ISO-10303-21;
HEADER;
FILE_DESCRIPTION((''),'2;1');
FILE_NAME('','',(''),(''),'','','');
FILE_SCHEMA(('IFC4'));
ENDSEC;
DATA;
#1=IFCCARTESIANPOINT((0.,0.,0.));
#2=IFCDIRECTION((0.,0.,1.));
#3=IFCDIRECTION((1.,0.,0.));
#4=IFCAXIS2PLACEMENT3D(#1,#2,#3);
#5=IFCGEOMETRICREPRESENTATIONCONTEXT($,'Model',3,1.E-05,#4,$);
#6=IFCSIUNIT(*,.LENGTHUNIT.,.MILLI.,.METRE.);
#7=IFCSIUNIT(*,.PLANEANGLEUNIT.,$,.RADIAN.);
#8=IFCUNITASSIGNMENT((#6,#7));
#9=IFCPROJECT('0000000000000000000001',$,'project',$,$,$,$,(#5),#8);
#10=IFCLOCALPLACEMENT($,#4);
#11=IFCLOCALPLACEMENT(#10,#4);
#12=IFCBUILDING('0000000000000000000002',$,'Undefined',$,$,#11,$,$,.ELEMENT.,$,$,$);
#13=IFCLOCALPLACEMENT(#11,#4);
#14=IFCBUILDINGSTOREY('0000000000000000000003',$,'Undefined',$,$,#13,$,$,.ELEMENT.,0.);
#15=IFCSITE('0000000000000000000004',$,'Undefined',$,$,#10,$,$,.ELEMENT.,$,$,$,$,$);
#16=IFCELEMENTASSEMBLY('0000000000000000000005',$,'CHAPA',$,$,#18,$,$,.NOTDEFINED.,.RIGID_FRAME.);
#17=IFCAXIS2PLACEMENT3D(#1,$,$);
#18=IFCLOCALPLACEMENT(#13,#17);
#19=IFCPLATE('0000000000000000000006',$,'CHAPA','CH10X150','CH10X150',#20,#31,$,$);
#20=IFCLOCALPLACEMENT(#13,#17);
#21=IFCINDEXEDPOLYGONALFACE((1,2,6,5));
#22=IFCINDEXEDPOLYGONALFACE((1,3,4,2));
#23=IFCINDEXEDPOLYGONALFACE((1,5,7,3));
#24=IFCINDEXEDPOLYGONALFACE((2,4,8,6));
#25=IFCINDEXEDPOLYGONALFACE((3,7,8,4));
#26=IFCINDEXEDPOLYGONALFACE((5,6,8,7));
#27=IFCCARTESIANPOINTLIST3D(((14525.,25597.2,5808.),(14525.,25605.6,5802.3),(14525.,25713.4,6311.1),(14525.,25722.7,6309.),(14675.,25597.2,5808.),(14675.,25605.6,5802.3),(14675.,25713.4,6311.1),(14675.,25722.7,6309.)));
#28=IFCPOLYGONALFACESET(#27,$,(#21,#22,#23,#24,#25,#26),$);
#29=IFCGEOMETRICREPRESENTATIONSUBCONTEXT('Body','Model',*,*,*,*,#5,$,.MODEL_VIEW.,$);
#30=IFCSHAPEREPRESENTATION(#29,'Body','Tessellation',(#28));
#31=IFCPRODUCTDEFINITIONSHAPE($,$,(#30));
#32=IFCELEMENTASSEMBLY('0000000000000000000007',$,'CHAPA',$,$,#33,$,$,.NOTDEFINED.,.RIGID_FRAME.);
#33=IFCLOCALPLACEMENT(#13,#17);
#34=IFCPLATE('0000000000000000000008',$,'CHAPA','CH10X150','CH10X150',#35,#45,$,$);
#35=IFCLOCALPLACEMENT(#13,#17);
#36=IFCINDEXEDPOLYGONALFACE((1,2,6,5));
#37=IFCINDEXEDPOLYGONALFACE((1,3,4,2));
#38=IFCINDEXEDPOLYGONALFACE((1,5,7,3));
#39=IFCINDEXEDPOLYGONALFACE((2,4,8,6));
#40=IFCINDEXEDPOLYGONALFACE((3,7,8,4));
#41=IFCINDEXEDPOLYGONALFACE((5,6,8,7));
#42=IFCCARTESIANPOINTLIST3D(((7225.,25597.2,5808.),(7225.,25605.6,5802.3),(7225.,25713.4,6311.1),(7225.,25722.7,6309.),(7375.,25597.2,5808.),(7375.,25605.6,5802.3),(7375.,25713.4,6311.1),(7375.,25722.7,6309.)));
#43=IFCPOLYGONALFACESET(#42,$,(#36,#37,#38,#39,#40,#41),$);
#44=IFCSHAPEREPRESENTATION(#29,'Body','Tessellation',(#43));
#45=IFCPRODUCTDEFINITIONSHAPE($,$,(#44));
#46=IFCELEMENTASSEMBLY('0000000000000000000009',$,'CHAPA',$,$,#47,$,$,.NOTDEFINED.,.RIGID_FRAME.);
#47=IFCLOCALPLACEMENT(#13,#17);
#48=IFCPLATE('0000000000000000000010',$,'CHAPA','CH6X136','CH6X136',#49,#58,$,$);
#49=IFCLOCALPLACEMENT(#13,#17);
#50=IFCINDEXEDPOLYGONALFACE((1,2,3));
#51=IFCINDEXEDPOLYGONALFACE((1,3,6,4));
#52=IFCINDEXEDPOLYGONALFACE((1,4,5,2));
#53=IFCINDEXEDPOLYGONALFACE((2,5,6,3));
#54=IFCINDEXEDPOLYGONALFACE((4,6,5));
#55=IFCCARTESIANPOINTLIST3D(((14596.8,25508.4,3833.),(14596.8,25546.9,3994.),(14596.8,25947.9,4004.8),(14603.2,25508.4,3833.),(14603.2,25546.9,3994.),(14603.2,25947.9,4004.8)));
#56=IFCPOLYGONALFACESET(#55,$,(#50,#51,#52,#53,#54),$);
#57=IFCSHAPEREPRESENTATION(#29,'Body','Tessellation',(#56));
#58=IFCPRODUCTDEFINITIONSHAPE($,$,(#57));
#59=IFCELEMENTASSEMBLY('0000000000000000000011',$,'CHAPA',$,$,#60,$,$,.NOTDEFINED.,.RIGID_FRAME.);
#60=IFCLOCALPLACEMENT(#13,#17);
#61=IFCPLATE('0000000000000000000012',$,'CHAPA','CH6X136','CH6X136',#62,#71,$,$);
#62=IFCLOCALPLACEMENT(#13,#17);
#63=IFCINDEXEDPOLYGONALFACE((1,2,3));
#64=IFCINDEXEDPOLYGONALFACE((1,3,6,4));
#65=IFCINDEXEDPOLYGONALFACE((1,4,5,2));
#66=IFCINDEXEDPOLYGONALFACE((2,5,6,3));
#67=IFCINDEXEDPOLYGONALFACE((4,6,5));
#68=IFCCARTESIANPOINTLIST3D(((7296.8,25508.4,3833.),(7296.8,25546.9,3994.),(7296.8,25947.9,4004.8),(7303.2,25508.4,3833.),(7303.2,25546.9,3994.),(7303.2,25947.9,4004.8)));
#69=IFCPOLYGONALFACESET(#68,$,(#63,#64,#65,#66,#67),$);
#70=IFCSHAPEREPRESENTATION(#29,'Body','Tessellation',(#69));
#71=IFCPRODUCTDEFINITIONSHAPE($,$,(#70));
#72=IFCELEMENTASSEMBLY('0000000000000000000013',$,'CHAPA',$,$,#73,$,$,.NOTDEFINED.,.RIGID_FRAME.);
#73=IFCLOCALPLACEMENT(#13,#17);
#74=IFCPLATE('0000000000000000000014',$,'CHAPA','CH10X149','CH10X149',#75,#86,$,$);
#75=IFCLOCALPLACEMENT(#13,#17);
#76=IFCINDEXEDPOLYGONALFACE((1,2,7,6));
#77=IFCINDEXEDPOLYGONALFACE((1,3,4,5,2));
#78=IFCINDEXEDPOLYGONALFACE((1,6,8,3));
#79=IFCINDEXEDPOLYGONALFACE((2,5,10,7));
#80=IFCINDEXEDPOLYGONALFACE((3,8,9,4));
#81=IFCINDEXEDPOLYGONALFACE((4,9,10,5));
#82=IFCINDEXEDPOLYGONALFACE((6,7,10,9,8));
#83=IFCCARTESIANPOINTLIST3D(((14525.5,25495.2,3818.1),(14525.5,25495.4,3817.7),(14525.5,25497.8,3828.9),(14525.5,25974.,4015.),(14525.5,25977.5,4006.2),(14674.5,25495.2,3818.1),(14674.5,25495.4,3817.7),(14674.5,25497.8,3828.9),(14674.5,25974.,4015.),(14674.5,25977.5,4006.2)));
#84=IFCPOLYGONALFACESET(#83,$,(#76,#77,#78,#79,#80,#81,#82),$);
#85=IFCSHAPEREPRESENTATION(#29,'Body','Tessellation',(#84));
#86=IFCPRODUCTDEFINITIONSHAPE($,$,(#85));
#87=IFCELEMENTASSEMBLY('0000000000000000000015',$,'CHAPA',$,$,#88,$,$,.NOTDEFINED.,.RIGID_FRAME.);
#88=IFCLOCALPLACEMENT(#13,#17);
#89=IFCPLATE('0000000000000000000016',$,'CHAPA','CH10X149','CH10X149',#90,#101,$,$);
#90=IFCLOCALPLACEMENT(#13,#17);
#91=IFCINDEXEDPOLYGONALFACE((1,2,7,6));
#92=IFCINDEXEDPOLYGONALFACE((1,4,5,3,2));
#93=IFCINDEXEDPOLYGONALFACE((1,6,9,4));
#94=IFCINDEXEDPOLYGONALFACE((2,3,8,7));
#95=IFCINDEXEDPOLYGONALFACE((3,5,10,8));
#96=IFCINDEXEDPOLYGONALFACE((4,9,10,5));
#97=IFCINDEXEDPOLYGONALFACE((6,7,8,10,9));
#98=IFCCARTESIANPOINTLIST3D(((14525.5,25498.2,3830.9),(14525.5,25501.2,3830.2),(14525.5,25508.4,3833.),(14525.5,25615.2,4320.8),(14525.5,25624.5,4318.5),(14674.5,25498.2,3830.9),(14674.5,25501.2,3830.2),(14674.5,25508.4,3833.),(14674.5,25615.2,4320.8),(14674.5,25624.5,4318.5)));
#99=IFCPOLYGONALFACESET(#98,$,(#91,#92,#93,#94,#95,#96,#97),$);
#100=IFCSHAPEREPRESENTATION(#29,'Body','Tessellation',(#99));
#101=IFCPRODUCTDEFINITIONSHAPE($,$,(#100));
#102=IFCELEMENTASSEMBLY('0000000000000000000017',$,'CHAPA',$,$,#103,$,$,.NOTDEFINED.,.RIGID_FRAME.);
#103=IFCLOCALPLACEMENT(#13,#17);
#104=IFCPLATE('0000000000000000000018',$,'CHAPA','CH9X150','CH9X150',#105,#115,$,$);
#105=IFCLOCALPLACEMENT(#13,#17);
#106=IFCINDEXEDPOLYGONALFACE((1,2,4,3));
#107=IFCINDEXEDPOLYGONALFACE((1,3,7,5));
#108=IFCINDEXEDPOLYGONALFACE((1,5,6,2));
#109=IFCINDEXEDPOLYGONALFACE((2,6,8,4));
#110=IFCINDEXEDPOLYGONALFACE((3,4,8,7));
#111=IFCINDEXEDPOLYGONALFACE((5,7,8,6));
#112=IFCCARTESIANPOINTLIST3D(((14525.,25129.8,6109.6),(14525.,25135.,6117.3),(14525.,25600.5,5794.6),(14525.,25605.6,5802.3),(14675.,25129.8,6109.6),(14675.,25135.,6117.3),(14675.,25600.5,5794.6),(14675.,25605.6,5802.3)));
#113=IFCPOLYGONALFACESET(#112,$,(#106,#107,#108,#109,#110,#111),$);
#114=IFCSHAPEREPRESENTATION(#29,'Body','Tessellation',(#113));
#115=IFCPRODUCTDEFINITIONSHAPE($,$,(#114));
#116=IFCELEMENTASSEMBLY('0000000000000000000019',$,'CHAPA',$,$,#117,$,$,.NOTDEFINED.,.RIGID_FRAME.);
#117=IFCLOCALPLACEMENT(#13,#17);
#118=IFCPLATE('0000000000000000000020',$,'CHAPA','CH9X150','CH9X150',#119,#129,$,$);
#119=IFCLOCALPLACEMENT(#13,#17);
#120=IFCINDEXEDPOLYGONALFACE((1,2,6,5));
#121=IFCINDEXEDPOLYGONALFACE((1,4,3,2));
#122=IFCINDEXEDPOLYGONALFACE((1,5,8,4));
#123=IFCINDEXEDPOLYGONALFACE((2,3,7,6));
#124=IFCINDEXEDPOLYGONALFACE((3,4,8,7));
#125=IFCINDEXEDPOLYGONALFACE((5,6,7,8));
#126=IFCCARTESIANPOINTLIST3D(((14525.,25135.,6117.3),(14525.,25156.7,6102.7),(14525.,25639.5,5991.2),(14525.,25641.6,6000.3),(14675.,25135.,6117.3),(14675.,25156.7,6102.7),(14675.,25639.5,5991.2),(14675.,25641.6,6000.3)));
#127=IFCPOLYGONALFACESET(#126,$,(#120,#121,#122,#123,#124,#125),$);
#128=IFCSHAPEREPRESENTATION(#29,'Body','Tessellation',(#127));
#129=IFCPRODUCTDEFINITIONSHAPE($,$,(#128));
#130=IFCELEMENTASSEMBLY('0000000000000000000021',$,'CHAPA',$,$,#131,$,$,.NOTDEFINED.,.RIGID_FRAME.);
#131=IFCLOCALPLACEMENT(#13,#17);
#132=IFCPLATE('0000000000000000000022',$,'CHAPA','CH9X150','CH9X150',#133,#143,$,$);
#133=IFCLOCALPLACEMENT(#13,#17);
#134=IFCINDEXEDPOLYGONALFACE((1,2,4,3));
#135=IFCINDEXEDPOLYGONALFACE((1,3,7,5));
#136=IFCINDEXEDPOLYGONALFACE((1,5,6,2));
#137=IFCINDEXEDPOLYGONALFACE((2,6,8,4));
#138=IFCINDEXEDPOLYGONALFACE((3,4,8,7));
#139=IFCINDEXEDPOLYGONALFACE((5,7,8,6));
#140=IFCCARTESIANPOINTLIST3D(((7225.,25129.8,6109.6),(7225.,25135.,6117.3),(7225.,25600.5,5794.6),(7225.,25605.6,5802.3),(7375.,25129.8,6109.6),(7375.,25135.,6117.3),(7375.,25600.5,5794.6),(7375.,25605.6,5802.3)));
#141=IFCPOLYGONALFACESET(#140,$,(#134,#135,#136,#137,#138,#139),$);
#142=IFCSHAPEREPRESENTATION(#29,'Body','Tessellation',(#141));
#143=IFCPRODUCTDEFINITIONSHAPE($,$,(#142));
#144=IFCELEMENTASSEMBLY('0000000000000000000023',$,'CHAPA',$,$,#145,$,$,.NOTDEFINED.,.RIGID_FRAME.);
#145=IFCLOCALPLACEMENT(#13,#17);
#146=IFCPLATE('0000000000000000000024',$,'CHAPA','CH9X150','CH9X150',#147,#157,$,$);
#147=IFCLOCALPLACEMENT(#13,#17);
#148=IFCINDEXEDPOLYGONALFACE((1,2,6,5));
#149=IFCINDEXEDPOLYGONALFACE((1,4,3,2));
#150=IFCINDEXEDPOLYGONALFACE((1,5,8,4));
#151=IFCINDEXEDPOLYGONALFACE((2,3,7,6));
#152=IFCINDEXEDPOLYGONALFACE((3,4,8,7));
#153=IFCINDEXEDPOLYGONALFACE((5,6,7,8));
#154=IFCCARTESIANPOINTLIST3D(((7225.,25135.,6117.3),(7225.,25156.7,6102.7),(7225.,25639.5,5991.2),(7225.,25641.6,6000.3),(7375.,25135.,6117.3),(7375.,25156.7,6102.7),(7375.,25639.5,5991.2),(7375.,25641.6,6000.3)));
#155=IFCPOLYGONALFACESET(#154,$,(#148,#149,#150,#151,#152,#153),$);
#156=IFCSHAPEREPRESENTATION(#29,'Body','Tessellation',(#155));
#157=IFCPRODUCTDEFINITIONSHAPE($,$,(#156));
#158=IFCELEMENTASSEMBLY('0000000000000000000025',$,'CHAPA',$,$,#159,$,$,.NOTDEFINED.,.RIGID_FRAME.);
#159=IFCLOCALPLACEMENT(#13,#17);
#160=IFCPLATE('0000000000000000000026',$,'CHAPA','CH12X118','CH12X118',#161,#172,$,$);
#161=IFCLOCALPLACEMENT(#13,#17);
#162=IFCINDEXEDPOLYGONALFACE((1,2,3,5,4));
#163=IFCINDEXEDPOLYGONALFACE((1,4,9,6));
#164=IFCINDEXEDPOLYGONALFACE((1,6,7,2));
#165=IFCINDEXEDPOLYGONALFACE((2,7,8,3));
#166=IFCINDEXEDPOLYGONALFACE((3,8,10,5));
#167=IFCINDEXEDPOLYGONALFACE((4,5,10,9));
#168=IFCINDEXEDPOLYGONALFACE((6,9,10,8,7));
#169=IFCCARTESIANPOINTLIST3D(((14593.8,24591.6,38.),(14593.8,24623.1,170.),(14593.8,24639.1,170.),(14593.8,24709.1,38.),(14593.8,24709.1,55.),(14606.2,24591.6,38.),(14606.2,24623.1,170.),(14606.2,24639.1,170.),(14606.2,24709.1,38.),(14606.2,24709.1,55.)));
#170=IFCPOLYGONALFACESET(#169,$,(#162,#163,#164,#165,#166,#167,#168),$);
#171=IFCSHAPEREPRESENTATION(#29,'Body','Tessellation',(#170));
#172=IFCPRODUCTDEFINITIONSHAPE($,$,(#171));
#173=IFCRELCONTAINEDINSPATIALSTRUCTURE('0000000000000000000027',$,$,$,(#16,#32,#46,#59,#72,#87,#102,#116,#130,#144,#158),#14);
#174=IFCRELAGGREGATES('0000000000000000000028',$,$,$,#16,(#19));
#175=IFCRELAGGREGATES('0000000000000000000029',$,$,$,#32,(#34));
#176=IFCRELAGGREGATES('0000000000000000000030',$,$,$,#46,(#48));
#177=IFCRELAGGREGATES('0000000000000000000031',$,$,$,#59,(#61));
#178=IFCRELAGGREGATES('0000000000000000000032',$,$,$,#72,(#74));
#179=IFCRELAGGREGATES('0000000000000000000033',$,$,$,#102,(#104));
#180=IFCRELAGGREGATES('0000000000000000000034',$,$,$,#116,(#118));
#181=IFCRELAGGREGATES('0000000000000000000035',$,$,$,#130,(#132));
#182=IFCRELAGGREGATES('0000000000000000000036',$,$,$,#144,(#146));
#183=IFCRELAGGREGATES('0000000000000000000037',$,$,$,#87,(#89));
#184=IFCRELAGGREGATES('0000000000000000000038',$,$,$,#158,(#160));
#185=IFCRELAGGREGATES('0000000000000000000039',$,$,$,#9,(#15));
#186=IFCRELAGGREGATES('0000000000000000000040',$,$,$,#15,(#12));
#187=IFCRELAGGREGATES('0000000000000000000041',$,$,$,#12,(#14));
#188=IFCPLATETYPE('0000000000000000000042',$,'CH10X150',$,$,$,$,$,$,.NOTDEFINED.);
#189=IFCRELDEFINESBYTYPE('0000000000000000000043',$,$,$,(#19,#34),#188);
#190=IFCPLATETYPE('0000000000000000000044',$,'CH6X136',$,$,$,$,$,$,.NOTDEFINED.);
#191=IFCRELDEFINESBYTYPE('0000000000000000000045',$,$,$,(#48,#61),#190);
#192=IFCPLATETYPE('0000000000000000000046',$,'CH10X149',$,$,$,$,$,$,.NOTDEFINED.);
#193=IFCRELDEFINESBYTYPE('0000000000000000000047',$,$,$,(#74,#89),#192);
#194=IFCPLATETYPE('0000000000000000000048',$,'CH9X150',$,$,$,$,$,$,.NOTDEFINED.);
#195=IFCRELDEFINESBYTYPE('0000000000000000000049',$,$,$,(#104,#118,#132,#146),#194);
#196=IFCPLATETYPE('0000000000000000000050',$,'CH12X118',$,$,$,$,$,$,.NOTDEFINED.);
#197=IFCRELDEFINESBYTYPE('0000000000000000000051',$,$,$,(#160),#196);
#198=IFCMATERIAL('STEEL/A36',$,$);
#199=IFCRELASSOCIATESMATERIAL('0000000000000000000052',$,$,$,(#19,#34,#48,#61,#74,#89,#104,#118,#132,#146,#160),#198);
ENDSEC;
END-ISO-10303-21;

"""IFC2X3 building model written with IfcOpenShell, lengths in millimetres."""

from ifc_helpers import new_model, si_unit, frame, origin_with_axes, place, context, subcontext, project, spatial, polyline, outline, extrude, clip, halfspace, material, type_object, element, aggregate, save


model = new_model("IFC2X3")

# Units and contexts
model_context = context("Model", 3, precision=1e-05, world=origin_with_axes())
body_context = subcontext(model_context, "Body", "Model", "MODEL_VIEW")
ifc_project = project(units=[si_unit("LENGTHUNIT", "METRE", prefix="MILLI"), si_unit("PLANEANGLEUNIT", "RADIAN")], contexts=[model_context])

# Site, building, storey
site_placement = place(None, origin_with_axes())
site = spatial("IfcSite", under=ifc_project, at=site_placement, Name="Undefined", CompositionType="ELEMENT")
building_placement = place(site_placement, origin_with_axes())
building = spatial("IfcBuilding", under=site, at=building_placement, Name="Undefined", CompositionType="ELEMENT")
storey_placement = place(building_placement, origin_with_axes())
storey = spatial("IfcBuildingStorey", under=building, at=storey_placement, Name="Undefined", CompositionType="ELEMENT", Elevation=0.0)

# Element assembly
assembly_1_placement = place(storey_placement, origin_with_axes())
assembly_1 = element("IfcElementAssembly", 1, at=assembly_1_placement, inside=storey, Name="CHAPA", AssemblyPlace="NOTDEFINED", PredefinedType="RIGID_FRAME")

# Plate
ifc_material_1 = material(Name="STEEL/A36")
plate_type_1 = type_object("IfcPlateType", Name="CH10X150", PredefinedType="NOTDEFINED")
plate_1_placement = place(assembly_1_placement, frame((14675.0, 25718.1, 6310.1), z_axis=(0.0, 0.97433, -0.225124), x_axis=(0.0, -0.225124, -0.97433)))
plate_1 = element("IfcPlate", 2, at=plate_1_placement, type_object=plate_type_1, material=ifc_material_1, Name="CHAPA", Description="CH10X150", ObjectType="CH10X150", context=body_context, shape_type="Clipping", body=[
    clip(extrude(outline(polyline([(0.0, 0.0), (520.0, 0.0), (520.0, 150.0), (0.0, 150.0), (0.0, 0.0)])), frame((0.0, 0.0, -4.8), z_axis=(0.0, 0.0, 1.0), x_axis=(1.0, 0.0, 0.0)), (0.0, 0.0, 1.0), 9.5), halfspace(frame((516.4, -500.0, -4.7), z_axis=(0.934951, 0.0, -0.354778), x_axis=(0.354778, 0.0, 0.934951)), False)),
])
aggregate(assembly_1, [plate_1])

# Element assemblies, plates
assembly_2_placement = place(storey_placement, origin_with_axes())
assembly_2 = element("IfcElementAssembly", 3, at=assembly_2_placement, inside=storey, Name="CHAPA", AssemblyPlace="NOTDEFINED", PredefinedType="RIGID_FRAME")
plate_2_placement = place(assembly_2_placement, frame((7375.0, 25718.1, 6310.1), z_axis=(0.0, 0.97433, -0.225124), x_axis=(0.0, -0.225124, -0.97433)))
plate_2 = element("IfcPlate", 4, at=plate_2_placement, type_object=plate_type_1, material=ifc_material_1, Name="CHAPA", Description="CH10X150", ObjectType="CH10X150", context=body_context, shape_type="Clipping", body=[
    clip(extrude(outline(polyline([(0.0, 0.0), (520.0, 0.0), (520.0, 150.0), (0.0, 150.0), (0.0, 0.0)])), frame((0.0, 0.0, -4.8), z_axis=(0.0, 0.0, 1.0), x_axis=(1.0, 0.0, 0.0)), (0.0, 0.0, 1.0), 9.5), halfspace(frame((516.4, -500.0, -4.7), z_axis=(0.934951, 0.0, -0.354778), x_axis=(0.354778, 0.0, 0.934951)), False)),
])
aggregate(assembly_2, [plate_2])
assembly_3_placement = place(storey_placement, origin_with_axes())
assembly_3 = element("IfcElementAssembly", 5, at=assembly_3_placement, inside=storey, Name="CHAPA", AssemblyPlace="NOTDEFINED", PredefinedType="RIGID_FRAME")
plate_type_2 = type_object("IfcPlateType", Name="CH6X136", PredefinedType="NOTDEFINED")
plate_3_placement = place(assembly_3_placement, frame((14600.0, 25546.9, 3994.0), z_axis=(-1.0, 0.0, 0.0), x_axis=(0.0, 0.999636, 0.026972)))
plate_3 = element("IfcPlate", 6, at=plate_3_placement, type_object=plate_type_2, material=ifc_material_1, Name="CHAPA", Description="CH6X136", ObjectType="CH6X136", context=body_context, shape_type="SweptSolid", body=[
    extrude(outline(polyline([(0.0, 0.0), (401.1, 0.0), (-42.8, 159.9), (0.0, 0.0)])), frame((0.0, 0.0, -3.1), z_axis=(0.0, 0.0, 1.0), x_axis=(1.0, 0.0, 0.0)), (0.0, 0.0, 1.0), 6.3),
])
aggregate(assembly_3, [plate_3])
assembly_4_placement = place(storey_placement, origin_with_axes())
assembly_4 = element("IfcElementAssembly", 7, at=assembly_4_placement, inside=storey, Name="CHAPA", AssemblyPlace="NOTDEFINED", PredefinedType="RIGID_FRAME")
plate_4_placement = place(assembly_4_placement, frame((7300.0, 25546.9, 3994.0), z_axis=(-1.0, 0.0, 0.0), x_axis=(0.0, 0.999636, 0.026972)))
plate_4 = element("IfcPlate", 8, at=plate_4_placement, type_object=plate_type_2, material=ifc_material_1, Name="CHAPA", Description="CH6X136", ObjectType="CH6X136", context=body_context, shape_type="SweptSolid", body=[
    extrude(outline(polyline([(0.0, 0.0), (401.1, 0.0), (-42.8, 159.9), (0.0, 0.0)])), frame((0.0, 0.0, -3.1), z_axis=(0.0, 0.0, 1.0), x_axis=(1.0, 0.0, 0.0)), (0.0, 0.0, 1.0), 6.3),
])
aggregate(assembly_4, [plate_4])
assembly_5_placement = place(storey_placement, origin_with_axes())
assembly_5 = element("IfcElementAssembly", 9, at=assembly_5_placement, inside=storey, Name="CHAPA", AssemblyPlace="NOTDEFINED", PredefinedType="RIGID_FRAME")
plate_type_3 = type_object("IfcPlateType", Name="CH10X149", PredefinedType="NOTDEFINED")
plate_5_placement = place(assembly_5_placement, frame((14525.5, 25975.7, 4010.6), z_axis=(0.0, 0.364063, -0.931374), x_axis=(1.0, 0.0, 0.0)))
plate_5 = element("IfcPlate", 10, at=plate_5_placement, type_object=plate_type_3, material=ifc_material_1, Name="CHAPA", Description="CH10X149", ObjectType="CH10X149", context=body_context, shape_type="Clipping", body=[
    clip(extrude(outline(polyline([(0.0, 0.0), (149.0, 0.0), (149.0, 517.6), (0.0, 517.6), (0.0, 0.0)])), frame((0.0, 0.0, -4.8), z_axis=(0.0, 0.0, 1.0), x_axis=(1.0, 0.0, 0.0)), (0.0, 0.0, 1.0), 9.5), halfspace(frame((149.0, 517.9, 4.7), z_axis=(0.0, 0.821204, -0.570634), x_axis=(-1.0, 0.0, 0.0)), False)),
])
aggregate(assembly_5, [plate_5])
assembly_6_placement = place(storey_placement, origin_with_axes())
assembly_6 = element("IfcElementAssembly", 11, at=assembly_6_placement, inside=storey, Name="CHAPA", AssemblyPlace="NOTDEFINED", PredefinedType="RIGID_FRAME")
plate_6_placement = place(assembly_6_placement, frame((14525.5, 25619.9, 4319.6), z_axis=(0.0, 0.972612, -0.232434), x_axis=(1.0, 0.000007, 0.000031)))
plate_6 = element("IfcPlate", 12, at=plate_6_placement, type_object=plate_type_3, material=ifc_material_1, Name="CHAPA", Description="CH10X149", ObjectType="CH10X149", context=body_context, shape_type="Clipping", body=[
    clip(extrude(outline(polyline([(0.0, 0.0), (70.9, 0.0), (149.0, 0.0), (149.0, 503.6), (0.0, 503.6), (0.0, 0.0)])), frame((0.0, 0.0, -4.8), z_axis=(0.0, 0.0, 1.0), x_axis=(1.0, 0.0, 0.0)), (0.0, 0.0, 1.0), 9.5), halfspace(frame((70.9, 499.2, 4.7), z_axis=(-0.000026, 0.821245, 0.570575), x_axis=(-1.0, -0.000032, 0.0)), False)),
])
assembly_7_placement = place(storey_placement, origin_with_axes())
assembly_7 = element("IfcElementAssembly", 13, at=assembly_7_placement, inside=storey, Name="CHAPA", AssemblyPlace="NOTDEFINED", PredefinedType="RIGID_FRAME")
plate_type_4 = type_object("IfcPlateType", Name="CH9X150", PredefinedType="NOTDEFINED")
plate_7_placement = place(assembly_7_placement, frame((14675.0, 25132.4, 6113.5), z_axis=(0.0, -0.55615, -0.831082), x_axis=(-1.0, 0.0, 0.0)))
plate_7 = element("IfcPlate", 14, at=plate_7_placement, type_object=plate_type_4, material=ifc_material_1, Name="CHAPA", Description="CH9X150", ObjectType="CH9X150", context=body_context, shape_type="SweptSolid", body=[
    extrude(outline(polyline([(0.0, 0.0), (150.0, 0.0), (150.0, 566.3), (0.0, 566.3), (0.0, 0.0)])), frame((0.0, 0.0, -4.7), z_axis=(0.0, 0.0, 1.0), x_axis=(1.0, 0.0, 0.0)), (0.0, 0.0, 1.0), 9.3),
])
aggregate(assembly_7, [plate_7])
assembly_8_placement = place(storey_placement, origin_with_axes())
assembly_8 = element("IfcElementAssembly", 15, at=assembly_8_placement, inside=storey, Name="CHAPA", AssemblyPlace="NOTDEFINED", PredefinedType="RIGID_FRAME")
plate_8_placement = place(assembly_8_placement, frame((14675.0, 25640.6, 5995.7), z_axis=(0.0, -0.225124, -0.97433), x_axis=(0.0, -0.97433, 0.225124)))
plate_8 = element("IfcPlate", 16, at=plate_8_placement, type_object=plate_type_4, material=ifc_material_1, Name="CHAPA", Description="CH9X150", ObjectType="CH9X150", context=body_context, shape_type="Clipping", body=[
    clip(extrude(outline(polyline([(0.0, 0.0), (520.0, 0.0), (520.0, 150.0), (0.0, 150.0), (0.0, 0.0)])), frame((0.0, 0.0, -4.7), z_axis=(0.0, 0.0, 1.0), x_axis=(1.0, 0.0, 0.0)), (0.0, 0.0, 1.0), 9.3), halfspace(frame((520.0, -500.0, -4.7), z_axis=(0.354778, 0.0, 0.934951), x_axis=(-0.934951, 0.0, 0.354778)), False)),
])
aggregate(assembly_8, [plate_8])
assembly_9_placement = place(storey_placement, origin_with_axes())
assembly_9 = element("IfcElementAssembly", 17, at=assembly_9_placement, inside=storey, Name="CHAPA", AssemblyPlace="NOTDEFINED", PredefinedType="RIGID_FRAME")
plate_9_placement = place(assembly_9_placement, frame((7375.0, 25132.4, 6113.5), z_axis=(0.0, -0.55615, -0.831082), x_axis=(-1.0, 0.0, 0.0)))
plate_9 = element("IfcPlate", 18, at=plate_9_placement, type_object=plate_type_4, material=ifc_material_1, Name="CHAPA", Description="CH9X150", ObjectType="CH9X150", context=body_context, shape_type="SweptSolid", body=[
    extrude(outline(polyline([(0.0, 0.0), (150.0, 0.0), (150.0, 566.3), (0.0, 566.3), (0.0, 0.0)])), frame((0.0, 0.0, -4.7), z_axis=(0.0, 0.0, 1.0), x_axis=(1.0, 0.0, 0.0)), (0.0, 0.0, 1.0), 9.3),
])
aggregate(assembly_9, [plate_9])
assembly_10_placement = place(storey_placement, origin_with_axes())
assembly_10 = element("IfcElementAssembly", 19, at=assembly_10_placement, inside=storey, Name="CHAPA", AssemblyPlace="NOTDEFINED", PredefinedType="RIGID_FRAME")
plate_10_placement = place(assembly_10_placement, frame((7375.0, 25640.6, 5995.7), z_axis=(0.0, -0.225124, -0.97433), x_axis=(0.0, -0.97433, 0.225124)))
plate_10 = element("IfcPlate", 20, at=plate_10_placement, type_object=plate_type_4, material=ifc_material_1, Name="CHAPA", Description="CH9X150", ObjectType="CH9X150", context=body_context, shape_type="Clipping", body=[
    clip(extrude(outline(polyline([(0.0, 0.0), (520.0, 0.0), (520.0, 150.0), (0.0, 150.0), (0.0, 0.0)])), frame((0.0, 0.0, -4.7), z_axis=(0.0, 0.0, 1.0), x_axis=(1.0, 0.0, 0.0)), (0.0, 0.0, 1.0), 9.3), halfspace(frame((520.0, -500.0, -4.7), z_axis=(0.354778, 0.0, 0.934951), x_axis=(-0.934951, 0.0, 0.354778)), False)),
])
aggregate(assembly_10, [plate_10])
assembly_11_placement = place(storey_placement, origin_with_axes())
assembly_11 = element("IfcElementAssembly", 21, at=assembly_11_placement, inside=storey, Name="CHAPA", AssemblyPlace="NOTDEFINED", PredefinedType="RIGID_FRAME")
plate_type_5 = type_object("IfcPlateType", Name="CH12X118", PredefinedType="NOTDEFINED")
plate_11_placement = place(assembly_11_placement, frame((14600.0, 24709.1, 38.0), z_axis=(-1.0, 0.0, 0.0), x_axis=(0.0, -1.0, 0.0)))
plate_11 = element("IfcPlate", 22, at=plate_11_placement, type_object=plate_type_5, material=ifc_material_1, Name="CHAPA", Description="CH12X118", ObjectType="CH12X118", context=body_context, shape_type="SweptSolid", body=[
    extrude(outline(polyline([(0.0, 0.0), (117.5, 0.0), (85.9, 132.0), (70.0, 132.0), (0.0, 17.0), (0.0, 0.0)])), frame((0.0, 0.0, -6.2), z_axis=(0.0, 0.0, 1.0), x_axis=(1.0, 0.0, 0.0)), (0.0, 0.0, 1.0), 12.5),
])

aggregate(assembly_6, [plate_6])

aggregate(assembly_11, [plate_11])

save(model, "model.ifc")
